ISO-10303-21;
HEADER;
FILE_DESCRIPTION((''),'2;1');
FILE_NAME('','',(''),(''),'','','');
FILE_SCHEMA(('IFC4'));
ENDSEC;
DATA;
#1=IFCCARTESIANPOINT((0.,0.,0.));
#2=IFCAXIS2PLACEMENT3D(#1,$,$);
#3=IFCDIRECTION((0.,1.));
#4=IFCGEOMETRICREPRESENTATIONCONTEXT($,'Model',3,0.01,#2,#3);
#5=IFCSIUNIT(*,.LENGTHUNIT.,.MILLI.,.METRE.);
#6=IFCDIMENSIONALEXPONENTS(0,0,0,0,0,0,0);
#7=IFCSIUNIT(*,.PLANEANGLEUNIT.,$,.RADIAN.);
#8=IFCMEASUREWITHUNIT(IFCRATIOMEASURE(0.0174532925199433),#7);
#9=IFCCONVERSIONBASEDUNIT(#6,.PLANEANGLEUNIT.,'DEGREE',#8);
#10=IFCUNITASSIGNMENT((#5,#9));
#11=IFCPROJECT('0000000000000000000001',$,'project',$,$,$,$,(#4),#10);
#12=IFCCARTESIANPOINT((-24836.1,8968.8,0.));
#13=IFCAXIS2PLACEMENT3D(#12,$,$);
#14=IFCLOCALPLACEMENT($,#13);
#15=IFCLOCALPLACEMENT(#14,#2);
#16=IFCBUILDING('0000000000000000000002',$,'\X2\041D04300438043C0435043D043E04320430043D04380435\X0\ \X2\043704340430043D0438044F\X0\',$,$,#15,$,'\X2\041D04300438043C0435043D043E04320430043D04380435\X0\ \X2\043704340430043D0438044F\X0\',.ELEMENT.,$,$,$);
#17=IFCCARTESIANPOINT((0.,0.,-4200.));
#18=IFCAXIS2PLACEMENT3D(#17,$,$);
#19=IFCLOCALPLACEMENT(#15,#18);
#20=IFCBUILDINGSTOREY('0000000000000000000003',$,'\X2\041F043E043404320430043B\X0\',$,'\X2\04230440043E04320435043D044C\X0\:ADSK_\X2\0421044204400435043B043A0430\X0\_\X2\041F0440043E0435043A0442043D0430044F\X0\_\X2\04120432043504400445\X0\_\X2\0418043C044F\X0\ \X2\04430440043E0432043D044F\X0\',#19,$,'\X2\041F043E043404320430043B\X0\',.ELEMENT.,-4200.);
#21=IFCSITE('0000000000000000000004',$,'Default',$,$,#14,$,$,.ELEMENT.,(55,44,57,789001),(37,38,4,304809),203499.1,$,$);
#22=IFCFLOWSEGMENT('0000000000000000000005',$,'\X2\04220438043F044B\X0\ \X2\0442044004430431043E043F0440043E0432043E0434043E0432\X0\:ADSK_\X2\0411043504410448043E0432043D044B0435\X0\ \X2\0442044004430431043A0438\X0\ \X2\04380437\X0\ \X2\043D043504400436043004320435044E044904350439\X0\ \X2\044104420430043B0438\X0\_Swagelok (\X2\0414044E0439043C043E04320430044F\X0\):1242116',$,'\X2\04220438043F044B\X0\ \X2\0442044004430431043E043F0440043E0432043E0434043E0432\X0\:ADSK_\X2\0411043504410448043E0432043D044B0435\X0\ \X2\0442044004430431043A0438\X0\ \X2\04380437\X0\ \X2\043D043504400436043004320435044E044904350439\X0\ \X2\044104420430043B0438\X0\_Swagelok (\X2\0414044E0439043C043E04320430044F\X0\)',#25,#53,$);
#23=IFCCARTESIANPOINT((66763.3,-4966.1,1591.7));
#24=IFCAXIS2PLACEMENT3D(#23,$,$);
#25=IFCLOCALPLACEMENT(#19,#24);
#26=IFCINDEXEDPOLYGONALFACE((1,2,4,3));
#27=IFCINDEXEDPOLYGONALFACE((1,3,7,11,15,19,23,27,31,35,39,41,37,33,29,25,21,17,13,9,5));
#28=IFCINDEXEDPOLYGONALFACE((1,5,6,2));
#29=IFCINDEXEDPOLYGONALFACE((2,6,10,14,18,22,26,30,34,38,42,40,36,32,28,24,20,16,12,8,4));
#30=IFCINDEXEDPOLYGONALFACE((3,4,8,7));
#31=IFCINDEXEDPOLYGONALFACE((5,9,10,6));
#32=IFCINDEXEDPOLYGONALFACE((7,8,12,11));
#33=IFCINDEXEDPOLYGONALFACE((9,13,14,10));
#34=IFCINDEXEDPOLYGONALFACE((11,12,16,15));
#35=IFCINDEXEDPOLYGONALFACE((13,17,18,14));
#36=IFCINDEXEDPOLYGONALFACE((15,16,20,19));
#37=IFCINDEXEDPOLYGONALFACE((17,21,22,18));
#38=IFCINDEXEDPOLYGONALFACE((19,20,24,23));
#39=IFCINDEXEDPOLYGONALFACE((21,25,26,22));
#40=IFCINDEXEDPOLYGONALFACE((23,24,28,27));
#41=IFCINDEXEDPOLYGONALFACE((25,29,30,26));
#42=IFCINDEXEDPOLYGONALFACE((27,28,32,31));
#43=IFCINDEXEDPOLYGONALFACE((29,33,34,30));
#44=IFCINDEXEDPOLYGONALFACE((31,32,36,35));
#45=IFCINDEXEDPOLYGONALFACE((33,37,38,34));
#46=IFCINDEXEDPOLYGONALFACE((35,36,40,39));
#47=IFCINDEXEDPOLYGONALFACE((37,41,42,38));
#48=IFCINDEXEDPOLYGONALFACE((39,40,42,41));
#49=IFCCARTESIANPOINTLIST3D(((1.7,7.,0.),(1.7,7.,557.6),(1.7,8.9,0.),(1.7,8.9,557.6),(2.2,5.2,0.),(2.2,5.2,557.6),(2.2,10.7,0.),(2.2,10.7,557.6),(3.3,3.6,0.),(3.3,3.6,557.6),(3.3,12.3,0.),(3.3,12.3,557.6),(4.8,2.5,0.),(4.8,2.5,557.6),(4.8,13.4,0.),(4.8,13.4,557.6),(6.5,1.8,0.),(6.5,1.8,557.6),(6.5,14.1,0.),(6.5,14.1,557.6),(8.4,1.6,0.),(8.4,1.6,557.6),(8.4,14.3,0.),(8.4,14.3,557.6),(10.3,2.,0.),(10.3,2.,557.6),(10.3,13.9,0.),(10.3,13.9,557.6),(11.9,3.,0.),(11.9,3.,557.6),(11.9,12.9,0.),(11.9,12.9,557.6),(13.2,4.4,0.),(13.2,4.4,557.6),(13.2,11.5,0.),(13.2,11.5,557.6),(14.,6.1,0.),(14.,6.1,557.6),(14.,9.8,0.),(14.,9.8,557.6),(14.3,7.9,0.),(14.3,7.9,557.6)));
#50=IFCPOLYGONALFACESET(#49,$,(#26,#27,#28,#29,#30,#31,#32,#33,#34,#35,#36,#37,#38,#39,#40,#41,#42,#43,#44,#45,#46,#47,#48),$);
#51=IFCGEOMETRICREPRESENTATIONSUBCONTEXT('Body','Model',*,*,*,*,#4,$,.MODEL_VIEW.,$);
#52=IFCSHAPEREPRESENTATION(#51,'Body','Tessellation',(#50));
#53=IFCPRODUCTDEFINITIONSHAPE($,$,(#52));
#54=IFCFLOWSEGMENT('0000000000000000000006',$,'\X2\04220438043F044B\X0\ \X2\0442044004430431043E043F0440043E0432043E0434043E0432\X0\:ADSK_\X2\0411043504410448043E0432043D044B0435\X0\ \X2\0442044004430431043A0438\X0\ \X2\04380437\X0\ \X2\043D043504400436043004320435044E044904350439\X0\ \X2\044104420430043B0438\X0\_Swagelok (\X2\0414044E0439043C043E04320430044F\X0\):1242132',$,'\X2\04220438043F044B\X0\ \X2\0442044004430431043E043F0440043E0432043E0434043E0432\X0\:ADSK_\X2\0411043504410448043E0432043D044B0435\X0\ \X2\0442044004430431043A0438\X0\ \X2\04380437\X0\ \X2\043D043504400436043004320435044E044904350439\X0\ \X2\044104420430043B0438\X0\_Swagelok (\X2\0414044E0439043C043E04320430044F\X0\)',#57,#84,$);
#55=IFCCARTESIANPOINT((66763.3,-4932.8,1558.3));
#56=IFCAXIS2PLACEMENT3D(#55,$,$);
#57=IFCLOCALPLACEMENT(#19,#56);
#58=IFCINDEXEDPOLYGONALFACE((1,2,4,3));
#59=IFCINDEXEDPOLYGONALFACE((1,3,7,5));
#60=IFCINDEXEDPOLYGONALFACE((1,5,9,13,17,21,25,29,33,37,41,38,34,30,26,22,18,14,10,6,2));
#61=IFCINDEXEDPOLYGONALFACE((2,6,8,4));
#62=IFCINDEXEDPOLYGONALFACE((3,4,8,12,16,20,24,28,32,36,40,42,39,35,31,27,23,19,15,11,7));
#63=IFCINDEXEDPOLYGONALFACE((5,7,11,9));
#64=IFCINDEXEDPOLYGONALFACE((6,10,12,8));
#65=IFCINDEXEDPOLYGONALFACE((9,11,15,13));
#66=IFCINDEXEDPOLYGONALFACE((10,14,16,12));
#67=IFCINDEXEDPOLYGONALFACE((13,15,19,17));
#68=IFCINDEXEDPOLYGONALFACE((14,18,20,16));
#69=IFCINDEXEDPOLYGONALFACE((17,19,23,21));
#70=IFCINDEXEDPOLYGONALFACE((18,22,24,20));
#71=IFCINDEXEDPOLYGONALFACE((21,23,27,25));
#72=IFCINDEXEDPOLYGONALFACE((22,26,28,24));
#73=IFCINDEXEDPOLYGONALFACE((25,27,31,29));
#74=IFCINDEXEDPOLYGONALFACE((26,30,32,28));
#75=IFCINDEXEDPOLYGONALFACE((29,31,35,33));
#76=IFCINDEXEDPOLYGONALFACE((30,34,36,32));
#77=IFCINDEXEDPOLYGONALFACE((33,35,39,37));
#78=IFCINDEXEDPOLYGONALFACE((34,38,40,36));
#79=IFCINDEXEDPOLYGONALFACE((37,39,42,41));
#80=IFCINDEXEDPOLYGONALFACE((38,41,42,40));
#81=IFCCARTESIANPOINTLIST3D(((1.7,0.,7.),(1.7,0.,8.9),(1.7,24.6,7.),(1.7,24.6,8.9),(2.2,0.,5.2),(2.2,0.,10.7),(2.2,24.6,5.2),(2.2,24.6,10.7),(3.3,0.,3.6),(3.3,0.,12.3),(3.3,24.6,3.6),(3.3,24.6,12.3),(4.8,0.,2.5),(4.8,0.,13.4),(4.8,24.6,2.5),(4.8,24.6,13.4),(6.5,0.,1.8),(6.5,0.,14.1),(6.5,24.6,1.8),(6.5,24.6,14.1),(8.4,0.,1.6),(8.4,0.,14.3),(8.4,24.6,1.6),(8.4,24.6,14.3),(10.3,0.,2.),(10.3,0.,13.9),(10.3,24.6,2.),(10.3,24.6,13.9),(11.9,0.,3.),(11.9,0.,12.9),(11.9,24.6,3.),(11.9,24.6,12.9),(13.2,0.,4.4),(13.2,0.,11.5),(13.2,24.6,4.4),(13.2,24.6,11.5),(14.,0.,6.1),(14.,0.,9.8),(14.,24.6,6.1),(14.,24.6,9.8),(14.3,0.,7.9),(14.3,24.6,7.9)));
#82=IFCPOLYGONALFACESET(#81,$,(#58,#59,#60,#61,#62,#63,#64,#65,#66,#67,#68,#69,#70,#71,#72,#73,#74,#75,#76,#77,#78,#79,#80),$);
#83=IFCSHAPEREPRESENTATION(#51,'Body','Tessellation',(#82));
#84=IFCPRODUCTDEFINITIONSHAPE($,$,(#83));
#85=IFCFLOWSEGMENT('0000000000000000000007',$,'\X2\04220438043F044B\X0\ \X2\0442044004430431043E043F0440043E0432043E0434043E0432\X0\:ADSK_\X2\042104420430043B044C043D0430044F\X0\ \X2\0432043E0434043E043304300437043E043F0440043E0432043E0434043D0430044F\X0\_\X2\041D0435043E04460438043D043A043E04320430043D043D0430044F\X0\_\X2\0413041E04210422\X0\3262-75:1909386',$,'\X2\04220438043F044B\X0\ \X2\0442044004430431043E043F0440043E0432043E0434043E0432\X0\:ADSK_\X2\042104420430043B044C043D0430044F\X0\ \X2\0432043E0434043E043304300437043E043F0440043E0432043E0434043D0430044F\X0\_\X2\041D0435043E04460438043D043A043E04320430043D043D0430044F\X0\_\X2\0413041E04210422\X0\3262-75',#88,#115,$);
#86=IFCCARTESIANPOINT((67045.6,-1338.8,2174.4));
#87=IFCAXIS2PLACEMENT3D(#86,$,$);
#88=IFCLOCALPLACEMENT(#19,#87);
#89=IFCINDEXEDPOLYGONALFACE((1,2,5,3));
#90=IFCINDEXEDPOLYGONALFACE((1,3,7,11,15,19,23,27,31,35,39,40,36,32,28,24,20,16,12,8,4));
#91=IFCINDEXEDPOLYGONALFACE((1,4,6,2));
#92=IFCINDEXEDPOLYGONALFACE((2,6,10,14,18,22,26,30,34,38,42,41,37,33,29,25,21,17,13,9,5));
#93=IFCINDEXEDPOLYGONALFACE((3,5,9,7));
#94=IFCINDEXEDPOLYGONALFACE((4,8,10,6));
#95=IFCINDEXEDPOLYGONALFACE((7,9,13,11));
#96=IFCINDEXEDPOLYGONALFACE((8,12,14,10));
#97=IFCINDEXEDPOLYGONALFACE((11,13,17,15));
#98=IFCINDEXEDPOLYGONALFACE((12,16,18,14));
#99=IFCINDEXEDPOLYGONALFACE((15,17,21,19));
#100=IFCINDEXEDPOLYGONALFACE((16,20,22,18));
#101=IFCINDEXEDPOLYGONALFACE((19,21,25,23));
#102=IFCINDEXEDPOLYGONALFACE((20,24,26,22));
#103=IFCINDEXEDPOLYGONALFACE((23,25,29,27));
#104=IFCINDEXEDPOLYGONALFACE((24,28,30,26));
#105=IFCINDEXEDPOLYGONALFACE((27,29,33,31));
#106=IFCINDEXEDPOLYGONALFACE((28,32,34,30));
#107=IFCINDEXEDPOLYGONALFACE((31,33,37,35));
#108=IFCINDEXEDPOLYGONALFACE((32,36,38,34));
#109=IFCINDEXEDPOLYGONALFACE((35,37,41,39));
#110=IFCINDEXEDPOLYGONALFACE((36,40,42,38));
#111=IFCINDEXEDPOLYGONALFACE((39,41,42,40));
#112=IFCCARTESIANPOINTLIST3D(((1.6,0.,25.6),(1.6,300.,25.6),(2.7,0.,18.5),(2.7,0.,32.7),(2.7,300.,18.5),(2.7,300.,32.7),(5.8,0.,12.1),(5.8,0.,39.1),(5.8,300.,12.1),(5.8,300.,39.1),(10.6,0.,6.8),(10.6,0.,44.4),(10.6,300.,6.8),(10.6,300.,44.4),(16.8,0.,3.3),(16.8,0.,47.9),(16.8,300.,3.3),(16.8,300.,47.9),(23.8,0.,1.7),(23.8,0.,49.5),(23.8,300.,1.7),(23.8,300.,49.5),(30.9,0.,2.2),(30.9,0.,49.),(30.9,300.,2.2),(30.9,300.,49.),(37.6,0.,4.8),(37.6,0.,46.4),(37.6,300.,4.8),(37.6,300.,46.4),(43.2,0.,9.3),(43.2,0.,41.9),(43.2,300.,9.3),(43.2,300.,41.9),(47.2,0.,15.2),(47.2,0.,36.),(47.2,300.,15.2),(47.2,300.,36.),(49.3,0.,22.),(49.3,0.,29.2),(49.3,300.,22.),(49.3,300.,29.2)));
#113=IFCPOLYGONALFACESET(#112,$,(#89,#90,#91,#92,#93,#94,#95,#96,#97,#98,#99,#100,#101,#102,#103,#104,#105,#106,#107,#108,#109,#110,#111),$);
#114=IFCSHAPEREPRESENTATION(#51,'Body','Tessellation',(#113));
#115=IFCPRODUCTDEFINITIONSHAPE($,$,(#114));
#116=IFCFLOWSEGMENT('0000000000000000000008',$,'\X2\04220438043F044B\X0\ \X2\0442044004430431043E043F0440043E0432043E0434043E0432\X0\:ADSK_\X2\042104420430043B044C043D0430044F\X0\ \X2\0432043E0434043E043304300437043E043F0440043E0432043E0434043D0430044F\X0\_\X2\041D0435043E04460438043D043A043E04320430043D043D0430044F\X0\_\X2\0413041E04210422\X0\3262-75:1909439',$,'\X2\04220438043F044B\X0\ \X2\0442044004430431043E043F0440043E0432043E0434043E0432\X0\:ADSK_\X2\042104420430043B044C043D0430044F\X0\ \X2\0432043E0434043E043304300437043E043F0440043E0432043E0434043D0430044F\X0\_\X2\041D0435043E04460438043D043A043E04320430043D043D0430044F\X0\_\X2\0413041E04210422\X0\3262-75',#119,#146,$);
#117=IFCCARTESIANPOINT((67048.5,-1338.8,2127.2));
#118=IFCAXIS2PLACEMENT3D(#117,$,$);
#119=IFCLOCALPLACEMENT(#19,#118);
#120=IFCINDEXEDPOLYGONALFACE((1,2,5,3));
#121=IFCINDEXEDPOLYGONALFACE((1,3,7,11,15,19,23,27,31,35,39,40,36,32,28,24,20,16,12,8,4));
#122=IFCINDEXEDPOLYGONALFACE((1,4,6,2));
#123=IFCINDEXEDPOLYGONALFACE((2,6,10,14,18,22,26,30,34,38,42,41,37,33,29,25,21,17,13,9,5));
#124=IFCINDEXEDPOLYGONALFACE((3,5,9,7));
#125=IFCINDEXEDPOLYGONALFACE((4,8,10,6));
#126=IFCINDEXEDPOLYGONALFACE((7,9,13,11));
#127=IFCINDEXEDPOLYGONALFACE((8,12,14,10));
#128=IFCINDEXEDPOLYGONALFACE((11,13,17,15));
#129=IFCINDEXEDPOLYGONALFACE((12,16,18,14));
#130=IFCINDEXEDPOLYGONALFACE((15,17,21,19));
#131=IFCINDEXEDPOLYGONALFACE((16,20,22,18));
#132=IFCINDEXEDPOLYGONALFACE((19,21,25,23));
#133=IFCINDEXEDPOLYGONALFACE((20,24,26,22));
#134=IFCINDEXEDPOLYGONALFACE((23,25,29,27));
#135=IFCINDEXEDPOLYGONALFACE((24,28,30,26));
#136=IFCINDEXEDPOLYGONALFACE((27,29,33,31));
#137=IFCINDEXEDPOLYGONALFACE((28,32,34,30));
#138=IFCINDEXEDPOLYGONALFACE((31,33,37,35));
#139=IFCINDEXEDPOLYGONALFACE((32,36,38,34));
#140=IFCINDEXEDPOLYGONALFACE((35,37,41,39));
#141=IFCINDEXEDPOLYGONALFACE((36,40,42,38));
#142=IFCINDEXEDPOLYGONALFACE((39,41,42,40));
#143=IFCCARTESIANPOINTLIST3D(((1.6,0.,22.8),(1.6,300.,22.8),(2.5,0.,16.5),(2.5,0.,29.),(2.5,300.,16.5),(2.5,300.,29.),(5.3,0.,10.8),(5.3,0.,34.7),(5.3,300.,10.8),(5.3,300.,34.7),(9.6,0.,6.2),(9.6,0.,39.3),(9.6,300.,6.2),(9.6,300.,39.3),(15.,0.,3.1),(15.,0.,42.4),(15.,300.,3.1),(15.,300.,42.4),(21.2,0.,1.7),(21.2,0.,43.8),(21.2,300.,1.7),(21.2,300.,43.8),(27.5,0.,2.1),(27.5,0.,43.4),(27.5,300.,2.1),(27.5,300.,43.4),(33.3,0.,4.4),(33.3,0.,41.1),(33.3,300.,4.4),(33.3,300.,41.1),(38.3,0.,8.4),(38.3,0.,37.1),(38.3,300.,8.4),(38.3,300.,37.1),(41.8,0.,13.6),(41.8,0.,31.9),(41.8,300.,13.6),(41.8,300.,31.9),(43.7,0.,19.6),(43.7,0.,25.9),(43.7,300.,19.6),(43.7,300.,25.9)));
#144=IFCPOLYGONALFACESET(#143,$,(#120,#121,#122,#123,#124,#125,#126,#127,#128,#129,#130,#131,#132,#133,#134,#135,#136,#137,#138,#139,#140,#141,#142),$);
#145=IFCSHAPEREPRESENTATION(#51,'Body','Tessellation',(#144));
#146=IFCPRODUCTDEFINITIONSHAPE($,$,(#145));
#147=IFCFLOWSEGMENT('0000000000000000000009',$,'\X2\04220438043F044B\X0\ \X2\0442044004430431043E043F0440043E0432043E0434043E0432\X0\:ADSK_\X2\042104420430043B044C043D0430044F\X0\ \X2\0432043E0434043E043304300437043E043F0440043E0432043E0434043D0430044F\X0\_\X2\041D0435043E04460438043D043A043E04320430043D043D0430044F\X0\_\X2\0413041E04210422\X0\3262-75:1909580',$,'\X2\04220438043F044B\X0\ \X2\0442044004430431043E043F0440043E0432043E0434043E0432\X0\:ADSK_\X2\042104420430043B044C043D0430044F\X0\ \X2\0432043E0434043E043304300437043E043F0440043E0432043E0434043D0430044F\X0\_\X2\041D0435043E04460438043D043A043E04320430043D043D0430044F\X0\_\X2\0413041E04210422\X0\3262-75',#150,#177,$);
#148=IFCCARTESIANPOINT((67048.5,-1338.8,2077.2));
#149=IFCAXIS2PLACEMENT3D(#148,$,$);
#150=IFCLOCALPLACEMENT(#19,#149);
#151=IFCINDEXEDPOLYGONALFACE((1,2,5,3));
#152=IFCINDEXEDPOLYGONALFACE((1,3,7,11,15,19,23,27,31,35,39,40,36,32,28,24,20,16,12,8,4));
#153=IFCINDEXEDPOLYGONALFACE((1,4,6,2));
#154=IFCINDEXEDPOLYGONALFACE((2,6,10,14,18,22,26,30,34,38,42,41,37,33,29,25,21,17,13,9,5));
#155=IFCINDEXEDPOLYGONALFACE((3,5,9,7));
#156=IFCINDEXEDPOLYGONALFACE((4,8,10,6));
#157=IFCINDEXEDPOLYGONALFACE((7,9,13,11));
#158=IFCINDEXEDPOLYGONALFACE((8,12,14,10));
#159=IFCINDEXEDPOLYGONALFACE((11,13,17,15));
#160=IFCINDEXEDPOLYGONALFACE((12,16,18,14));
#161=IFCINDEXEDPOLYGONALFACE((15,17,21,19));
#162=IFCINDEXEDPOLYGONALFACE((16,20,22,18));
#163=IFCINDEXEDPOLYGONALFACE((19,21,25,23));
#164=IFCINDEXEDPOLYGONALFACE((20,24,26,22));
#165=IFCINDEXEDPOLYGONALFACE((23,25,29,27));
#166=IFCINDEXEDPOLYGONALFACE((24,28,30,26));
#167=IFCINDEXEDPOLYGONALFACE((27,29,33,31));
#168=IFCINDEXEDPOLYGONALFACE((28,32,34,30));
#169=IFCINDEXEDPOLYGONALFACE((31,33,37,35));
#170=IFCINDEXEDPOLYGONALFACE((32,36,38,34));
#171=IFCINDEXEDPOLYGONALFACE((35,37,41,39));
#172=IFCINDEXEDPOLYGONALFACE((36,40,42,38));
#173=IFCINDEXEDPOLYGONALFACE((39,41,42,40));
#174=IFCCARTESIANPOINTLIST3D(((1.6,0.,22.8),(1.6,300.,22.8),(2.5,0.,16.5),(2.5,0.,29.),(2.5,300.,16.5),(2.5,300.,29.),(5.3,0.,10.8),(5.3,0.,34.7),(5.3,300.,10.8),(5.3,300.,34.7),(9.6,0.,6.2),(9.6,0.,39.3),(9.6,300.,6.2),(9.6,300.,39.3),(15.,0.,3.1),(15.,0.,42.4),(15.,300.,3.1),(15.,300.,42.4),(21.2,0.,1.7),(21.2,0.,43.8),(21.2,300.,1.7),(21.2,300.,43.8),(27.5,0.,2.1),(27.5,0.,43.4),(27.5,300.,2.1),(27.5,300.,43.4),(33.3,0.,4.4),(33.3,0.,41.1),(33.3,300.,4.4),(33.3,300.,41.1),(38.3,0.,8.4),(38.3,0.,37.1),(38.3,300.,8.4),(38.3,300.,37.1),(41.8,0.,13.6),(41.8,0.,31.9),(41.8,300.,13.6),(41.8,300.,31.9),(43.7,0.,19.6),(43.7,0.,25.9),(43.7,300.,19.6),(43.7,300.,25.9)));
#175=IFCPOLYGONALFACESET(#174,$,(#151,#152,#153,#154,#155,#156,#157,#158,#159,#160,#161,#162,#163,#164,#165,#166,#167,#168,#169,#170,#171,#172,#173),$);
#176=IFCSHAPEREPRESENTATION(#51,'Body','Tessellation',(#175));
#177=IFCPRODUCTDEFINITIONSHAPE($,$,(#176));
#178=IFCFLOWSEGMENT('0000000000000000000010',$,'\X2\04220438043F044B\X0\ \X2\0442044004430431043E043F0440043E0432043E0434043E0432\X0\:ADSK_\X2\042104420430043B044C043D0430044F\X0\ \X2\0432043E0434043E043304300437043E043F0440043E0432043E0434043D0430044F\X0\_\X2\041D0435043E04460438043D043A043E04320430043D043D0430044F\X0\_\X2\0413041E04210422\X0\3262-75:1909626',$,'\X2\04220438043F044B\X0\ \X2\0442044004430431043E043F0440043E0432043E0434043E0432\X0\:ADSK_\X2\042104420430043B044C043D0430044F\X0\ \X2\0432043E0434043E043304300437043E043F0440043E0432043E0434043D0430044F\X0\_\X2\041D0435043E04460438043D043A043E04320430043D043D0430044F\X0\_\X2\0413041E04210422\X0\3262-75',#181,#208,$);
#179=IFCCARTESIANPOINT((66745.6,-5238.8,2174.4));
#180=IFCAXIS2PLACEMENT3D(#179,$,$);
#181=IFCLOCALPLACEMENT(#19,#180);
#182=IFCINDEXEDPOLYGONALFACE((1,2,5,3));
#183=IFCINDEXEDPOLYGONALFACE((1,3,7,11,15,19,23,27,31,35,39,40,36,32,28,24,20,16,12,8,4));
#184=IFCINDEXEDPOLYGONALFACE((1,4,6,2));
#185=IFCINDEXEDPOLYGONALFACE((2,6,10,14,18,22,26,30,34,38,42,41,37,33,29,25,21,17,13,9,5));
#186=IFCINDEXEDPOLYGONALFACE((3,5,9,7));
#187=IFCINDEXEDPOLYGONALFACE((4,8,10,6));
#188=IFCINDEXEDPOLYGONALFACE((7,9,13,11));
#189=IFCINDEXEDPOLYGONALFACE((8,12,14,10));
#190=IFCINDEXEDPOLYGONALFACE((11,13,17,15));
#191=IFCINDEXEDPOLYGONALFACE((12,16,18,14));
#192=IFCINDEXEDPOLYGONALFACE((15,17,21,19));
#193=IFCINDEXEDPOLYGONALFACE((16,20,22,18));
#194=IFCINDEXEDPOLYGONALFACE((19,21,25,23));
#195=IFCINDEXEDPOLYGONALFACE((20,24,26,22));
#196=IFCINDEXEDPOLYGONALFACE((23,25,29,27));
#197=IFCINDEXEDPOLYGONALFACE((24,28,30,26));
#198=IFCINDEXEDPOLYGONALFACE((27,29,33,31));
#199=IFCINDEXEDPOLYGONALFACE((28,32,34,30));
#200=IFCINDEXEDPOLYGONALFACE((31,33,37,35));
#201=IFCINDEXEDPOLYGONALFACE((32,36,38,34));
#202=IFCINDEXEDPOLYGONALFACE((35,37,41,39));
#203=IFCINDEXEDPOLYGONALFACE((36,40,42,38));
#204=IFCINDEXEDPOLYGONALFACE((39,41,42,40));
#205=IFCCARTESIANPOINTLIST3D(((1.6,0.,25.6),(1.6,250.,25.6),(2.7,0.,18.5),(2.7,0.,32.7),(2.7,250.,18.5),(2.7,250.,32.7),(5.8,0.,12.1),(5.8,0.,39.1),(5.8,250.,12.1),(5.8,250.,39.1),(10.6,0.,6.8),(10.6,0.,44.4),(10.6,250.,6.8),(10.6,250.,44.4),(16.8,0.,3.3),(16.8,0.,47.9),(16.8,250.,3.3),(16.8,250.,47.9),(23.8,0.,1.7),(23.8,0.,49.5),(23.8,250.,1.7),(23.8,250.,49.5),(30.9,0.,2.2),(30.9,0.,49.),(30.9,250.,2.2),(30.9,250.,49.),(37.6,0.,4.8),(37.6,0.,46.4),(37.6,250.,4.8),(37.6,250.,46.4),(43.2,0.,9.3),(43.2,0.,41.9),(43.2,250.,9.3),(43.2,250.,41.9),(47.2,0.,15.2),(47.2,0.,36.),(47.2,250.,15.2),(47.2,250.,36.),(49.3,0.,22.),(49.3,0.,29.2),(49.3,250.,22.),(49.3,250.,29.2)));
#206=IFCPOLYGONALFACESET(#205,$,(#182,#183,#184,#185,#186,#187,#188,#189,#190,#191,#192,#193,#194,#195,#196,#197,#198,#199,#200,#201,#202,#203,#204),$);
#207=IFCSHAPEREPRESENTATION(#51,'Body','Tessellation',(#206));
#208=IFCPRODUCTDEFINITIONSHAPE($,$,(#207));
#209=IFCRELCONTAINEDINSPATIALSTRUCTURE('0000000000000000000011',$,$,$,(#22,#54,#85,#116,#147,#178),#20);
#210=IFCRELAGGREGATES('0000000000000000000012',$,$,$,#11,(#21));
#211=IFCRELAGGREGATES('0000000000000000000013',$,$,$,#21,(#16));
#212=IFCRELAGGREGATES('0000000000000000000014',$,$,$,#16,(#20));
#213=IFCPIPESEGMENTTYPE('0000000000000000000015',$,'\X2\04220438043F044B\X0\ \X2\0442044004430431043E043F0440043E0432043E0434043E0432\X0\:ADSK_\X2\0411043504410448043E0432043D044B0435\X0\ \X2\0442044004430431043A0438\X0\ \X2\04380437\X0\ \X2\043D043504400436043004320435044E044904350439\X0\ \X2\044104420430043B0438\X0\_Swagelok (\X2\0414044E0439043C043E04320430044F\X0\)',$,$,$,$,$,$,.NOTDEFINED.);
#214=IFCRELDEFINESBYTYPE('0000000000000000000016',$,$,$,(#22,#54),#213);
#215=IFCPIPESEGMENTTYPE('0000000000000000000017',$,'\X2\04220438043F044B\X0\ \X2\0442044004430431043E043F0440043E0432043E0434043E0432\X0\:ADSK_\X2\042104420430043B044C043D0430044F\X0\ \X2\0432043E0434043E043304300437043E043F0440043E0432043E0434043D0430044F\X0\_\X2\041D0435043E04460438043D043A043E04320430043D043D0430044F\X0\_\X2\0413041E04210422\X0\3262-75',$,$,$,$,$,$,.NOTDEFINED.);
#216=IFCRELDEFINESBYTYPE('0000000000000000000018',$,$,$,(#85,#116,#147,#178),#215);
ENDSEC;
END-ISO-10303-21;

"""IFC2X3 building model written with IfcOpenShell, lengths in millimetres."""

from ifc_helpers import new_model, entity, si_unit, converted_unit, direction, frame, origin, origin_2d_with_axis, place, context, subcontext, project, spatial, circle, extrude, type_object, element, save


model = new_model("IFC2X3")

# Units and contexts
model_context = context("Model", 3, precision=0.01, world=origin(), true_north=direction((0.0, 1.0)))
body_context = subcontext(model_context, "Body", "Model", "MODEL_VIEW")
ifc_project = project(units=[si_unit("LENGTHUNIT", "METRE", prefix="MILLI"), converted_unit("PLANEANGLEUNIT", "DEGREE", entity("IfcRatioMeasure", 0.0174532925199433), si_unit("PLANEANGLEUNIT", "RADIAN"), dimensions=[0, 0, 0, 0, 0, 0, 0])], contexts=[model_context])

# Site, building, storey
site_placement = place(None, frame((-24836.1, 8968.8, 0.0)))
site = spatial("IfcSite", under=ifc_project, at=site_placement, Name="Default", CompositionType="ELEMENT", RefLatitude=(55, 44, 57, 789001), RefLongitude=(37, 38, 4, 304809), RefElevation=203499.1)
building_placement = place(site_placement, origin())
building = spatial("IfcBuilding", under=site, at=building_placement, Name="Наименование здания", LongName="Наименование здания", CompositionType="ELEMENT")
storey_placement = place(building_placement, frame((0.0, 0.0, -4200.0)))
storey = spatial("IfcBuildingStorey", under=building, at=storey_placement, Name="Подвал", ObjectType="Уровень:ADSK_Стрелка_Проектная_Вверх_Имя уровня", LongName="Подвал", CompositionType="ELEMENT", Elevation=-4200.0)

# Flow segments
pipe_segment_type_1 = type_object("IfcPipeSegmentType", Name="Типы трубопроводов:ADSK_Бесшовные трубки из нержавеющей стали_Swagelok (Дюймовая)", PredefinedType="NOTDEFINED")
flow_segment_1_placement = place(storey_placement, frame((66763.3, -4966.1, 1591.7)))
element("IfcFlowSegment", 1, at=flow_segment_1_placement, inside=storey, type_object=pipe_segment_type_1, Name="Типы трубопроводов:ADSK_Бесшовные трубки из нержавеющей стали_Swagelok (Дюймовая):1242116", ObjectType="Типы трубопроводов:ADSK_Бесшовные трубки из нержавеющей стали_Swagelok (Дюймовая)", context=body_context, shape_type="SweptSolid", body=[
    extrude(circle(Radius=6.3, at=origin_2d_with_axis()), frame((8.0, 8.0, 0.0)), (0.0, 0.0, 1.0), 557.6),
])
flow_segment_2_placement = place(storey_placement, frame((66763.3, -4932.8, 1558.3)))
element("IfcFlowSegment", 2, at=flow_segment_2_placement, inside=storey, type_object=pipe_segment_type_1, Name="Типы трубопроводов:ADSK_Бесшовные трубки из нержавеющей стали_Swagelok (Дюймовая):1242132", ObjectType="Типы трубопроводов:ADSK_Бесшовные трубки из нержавеющей стали_Swagelok (Дюймовая)", context=body_context, shape_type="SweptSolid", body=[
    extrude(circle(Radius=6.3, at=origin_2d_with_axis()), frame((8.0, 0.0, 8.0), z_axis=(0.0, 1.0, 0.0), x_axis=(1.0, 0.0, 0.0)), (0.0, 0.0, 1.0), 24.6),
])
pipe_segment_type_2 = type_object("IfcPipeSegmentType", Name="Типы трубопроводов:ADSK_Стальная водогазопроводная_Неоцинкованная_ГОСТ3262-75", PredefinedType="NOTDEFINED")
flow_segment_3_placement = place(storey_placement, frame((67045.6, -1338.8, 2174.4)))
element("IfcFlowSegment", 3, at=flow_segment_3_placement, inside=storey, type_object=pipe_segment_type_2, Name="Типы трубопроводов:ADSK_Стальная водогазопроводная_Неоцинкованная_ГОСТ3262-75:1909386", ObjectType="Типы трубопроводов:ADSK_Стальная водогазопроводная_Неоцинкованная_ГОСТ3262-75", context=body_context, shape_type="SweptSolid", body=[
    extrude(circle(Radius=24.0, at=origin_2d_with_axis()), frame((25.6, 0.0, 25.6), z_axis=(0.0, 1.0, 0.0), x_axis=(-1.0, 0.0, 0.0)), (0.0, 0.0, 1.0), 300.0),
])
for number, where, name in (
    (4, (67048.5, -1338.8, 2127.2), "Типы трубопроводов:ADSK_Стальная водогазопроводная_Неоцинкованная_ГОСТ3262-75:1909439"),
    (5, (67048.5, -1338.8, 2077.2), "Типы трубопроводов:ADSK_Стальная водогазопроводная_Неоцинкованная_ГОСТ3262-75:1909580"),
):
    element("IfcFlowSegment", number, at=place(storey_placement, frame(where)), inside=storey, type_object=pipe_segment_type_2, Name=name, ObjectType="Типы трубопроводов:ADSK_Стальная водогазопроводная_Неоцинкованная_ГОСТ3262-75", context=body_context, shape_type="SweptSolid", body=[
        extrude(circle(Radius=21.1, at=origin_2d_with_axis()), frame((22.8, 0.0, 22.8), z_axis=(0.0, 1.0, 0.0), x_axis=(-1.0, 0.0, 0.0)), (0.0, 0.0, 1.0), 300.0),
    ])
flow_segment_4_placement = place(storey_placement, frame((66745.6, -5238.8, 2174.4)))
element("IfcFlowSegment", 6, at=flow_segment_4_placement, inside=storey, type_object=pipe_segment_type_2, Name="Типы трубопроводов:ADSK_Стальная водогазопроводная_Неоцинкованная_ГОСТ3262-75:1909626", ObjectType="Типы трубопроводов:ADSK_Стальная водогазопроводная_Неоцинкованная_ГОСТ3262-75", context=body_context, shape_type="SweptSolid", body=[
    extrude(circle(Radius=24.0, at=origin_2d_with_axis()), frame((25.6, 0.0, 25.6), z_axis=(0.0, 1.0, 0.0), x_axis=(-1.0, 0.0, 0.0)), (0.0, 0.0, 1.0), 250.0),
])

save(model, "model.ifc")
